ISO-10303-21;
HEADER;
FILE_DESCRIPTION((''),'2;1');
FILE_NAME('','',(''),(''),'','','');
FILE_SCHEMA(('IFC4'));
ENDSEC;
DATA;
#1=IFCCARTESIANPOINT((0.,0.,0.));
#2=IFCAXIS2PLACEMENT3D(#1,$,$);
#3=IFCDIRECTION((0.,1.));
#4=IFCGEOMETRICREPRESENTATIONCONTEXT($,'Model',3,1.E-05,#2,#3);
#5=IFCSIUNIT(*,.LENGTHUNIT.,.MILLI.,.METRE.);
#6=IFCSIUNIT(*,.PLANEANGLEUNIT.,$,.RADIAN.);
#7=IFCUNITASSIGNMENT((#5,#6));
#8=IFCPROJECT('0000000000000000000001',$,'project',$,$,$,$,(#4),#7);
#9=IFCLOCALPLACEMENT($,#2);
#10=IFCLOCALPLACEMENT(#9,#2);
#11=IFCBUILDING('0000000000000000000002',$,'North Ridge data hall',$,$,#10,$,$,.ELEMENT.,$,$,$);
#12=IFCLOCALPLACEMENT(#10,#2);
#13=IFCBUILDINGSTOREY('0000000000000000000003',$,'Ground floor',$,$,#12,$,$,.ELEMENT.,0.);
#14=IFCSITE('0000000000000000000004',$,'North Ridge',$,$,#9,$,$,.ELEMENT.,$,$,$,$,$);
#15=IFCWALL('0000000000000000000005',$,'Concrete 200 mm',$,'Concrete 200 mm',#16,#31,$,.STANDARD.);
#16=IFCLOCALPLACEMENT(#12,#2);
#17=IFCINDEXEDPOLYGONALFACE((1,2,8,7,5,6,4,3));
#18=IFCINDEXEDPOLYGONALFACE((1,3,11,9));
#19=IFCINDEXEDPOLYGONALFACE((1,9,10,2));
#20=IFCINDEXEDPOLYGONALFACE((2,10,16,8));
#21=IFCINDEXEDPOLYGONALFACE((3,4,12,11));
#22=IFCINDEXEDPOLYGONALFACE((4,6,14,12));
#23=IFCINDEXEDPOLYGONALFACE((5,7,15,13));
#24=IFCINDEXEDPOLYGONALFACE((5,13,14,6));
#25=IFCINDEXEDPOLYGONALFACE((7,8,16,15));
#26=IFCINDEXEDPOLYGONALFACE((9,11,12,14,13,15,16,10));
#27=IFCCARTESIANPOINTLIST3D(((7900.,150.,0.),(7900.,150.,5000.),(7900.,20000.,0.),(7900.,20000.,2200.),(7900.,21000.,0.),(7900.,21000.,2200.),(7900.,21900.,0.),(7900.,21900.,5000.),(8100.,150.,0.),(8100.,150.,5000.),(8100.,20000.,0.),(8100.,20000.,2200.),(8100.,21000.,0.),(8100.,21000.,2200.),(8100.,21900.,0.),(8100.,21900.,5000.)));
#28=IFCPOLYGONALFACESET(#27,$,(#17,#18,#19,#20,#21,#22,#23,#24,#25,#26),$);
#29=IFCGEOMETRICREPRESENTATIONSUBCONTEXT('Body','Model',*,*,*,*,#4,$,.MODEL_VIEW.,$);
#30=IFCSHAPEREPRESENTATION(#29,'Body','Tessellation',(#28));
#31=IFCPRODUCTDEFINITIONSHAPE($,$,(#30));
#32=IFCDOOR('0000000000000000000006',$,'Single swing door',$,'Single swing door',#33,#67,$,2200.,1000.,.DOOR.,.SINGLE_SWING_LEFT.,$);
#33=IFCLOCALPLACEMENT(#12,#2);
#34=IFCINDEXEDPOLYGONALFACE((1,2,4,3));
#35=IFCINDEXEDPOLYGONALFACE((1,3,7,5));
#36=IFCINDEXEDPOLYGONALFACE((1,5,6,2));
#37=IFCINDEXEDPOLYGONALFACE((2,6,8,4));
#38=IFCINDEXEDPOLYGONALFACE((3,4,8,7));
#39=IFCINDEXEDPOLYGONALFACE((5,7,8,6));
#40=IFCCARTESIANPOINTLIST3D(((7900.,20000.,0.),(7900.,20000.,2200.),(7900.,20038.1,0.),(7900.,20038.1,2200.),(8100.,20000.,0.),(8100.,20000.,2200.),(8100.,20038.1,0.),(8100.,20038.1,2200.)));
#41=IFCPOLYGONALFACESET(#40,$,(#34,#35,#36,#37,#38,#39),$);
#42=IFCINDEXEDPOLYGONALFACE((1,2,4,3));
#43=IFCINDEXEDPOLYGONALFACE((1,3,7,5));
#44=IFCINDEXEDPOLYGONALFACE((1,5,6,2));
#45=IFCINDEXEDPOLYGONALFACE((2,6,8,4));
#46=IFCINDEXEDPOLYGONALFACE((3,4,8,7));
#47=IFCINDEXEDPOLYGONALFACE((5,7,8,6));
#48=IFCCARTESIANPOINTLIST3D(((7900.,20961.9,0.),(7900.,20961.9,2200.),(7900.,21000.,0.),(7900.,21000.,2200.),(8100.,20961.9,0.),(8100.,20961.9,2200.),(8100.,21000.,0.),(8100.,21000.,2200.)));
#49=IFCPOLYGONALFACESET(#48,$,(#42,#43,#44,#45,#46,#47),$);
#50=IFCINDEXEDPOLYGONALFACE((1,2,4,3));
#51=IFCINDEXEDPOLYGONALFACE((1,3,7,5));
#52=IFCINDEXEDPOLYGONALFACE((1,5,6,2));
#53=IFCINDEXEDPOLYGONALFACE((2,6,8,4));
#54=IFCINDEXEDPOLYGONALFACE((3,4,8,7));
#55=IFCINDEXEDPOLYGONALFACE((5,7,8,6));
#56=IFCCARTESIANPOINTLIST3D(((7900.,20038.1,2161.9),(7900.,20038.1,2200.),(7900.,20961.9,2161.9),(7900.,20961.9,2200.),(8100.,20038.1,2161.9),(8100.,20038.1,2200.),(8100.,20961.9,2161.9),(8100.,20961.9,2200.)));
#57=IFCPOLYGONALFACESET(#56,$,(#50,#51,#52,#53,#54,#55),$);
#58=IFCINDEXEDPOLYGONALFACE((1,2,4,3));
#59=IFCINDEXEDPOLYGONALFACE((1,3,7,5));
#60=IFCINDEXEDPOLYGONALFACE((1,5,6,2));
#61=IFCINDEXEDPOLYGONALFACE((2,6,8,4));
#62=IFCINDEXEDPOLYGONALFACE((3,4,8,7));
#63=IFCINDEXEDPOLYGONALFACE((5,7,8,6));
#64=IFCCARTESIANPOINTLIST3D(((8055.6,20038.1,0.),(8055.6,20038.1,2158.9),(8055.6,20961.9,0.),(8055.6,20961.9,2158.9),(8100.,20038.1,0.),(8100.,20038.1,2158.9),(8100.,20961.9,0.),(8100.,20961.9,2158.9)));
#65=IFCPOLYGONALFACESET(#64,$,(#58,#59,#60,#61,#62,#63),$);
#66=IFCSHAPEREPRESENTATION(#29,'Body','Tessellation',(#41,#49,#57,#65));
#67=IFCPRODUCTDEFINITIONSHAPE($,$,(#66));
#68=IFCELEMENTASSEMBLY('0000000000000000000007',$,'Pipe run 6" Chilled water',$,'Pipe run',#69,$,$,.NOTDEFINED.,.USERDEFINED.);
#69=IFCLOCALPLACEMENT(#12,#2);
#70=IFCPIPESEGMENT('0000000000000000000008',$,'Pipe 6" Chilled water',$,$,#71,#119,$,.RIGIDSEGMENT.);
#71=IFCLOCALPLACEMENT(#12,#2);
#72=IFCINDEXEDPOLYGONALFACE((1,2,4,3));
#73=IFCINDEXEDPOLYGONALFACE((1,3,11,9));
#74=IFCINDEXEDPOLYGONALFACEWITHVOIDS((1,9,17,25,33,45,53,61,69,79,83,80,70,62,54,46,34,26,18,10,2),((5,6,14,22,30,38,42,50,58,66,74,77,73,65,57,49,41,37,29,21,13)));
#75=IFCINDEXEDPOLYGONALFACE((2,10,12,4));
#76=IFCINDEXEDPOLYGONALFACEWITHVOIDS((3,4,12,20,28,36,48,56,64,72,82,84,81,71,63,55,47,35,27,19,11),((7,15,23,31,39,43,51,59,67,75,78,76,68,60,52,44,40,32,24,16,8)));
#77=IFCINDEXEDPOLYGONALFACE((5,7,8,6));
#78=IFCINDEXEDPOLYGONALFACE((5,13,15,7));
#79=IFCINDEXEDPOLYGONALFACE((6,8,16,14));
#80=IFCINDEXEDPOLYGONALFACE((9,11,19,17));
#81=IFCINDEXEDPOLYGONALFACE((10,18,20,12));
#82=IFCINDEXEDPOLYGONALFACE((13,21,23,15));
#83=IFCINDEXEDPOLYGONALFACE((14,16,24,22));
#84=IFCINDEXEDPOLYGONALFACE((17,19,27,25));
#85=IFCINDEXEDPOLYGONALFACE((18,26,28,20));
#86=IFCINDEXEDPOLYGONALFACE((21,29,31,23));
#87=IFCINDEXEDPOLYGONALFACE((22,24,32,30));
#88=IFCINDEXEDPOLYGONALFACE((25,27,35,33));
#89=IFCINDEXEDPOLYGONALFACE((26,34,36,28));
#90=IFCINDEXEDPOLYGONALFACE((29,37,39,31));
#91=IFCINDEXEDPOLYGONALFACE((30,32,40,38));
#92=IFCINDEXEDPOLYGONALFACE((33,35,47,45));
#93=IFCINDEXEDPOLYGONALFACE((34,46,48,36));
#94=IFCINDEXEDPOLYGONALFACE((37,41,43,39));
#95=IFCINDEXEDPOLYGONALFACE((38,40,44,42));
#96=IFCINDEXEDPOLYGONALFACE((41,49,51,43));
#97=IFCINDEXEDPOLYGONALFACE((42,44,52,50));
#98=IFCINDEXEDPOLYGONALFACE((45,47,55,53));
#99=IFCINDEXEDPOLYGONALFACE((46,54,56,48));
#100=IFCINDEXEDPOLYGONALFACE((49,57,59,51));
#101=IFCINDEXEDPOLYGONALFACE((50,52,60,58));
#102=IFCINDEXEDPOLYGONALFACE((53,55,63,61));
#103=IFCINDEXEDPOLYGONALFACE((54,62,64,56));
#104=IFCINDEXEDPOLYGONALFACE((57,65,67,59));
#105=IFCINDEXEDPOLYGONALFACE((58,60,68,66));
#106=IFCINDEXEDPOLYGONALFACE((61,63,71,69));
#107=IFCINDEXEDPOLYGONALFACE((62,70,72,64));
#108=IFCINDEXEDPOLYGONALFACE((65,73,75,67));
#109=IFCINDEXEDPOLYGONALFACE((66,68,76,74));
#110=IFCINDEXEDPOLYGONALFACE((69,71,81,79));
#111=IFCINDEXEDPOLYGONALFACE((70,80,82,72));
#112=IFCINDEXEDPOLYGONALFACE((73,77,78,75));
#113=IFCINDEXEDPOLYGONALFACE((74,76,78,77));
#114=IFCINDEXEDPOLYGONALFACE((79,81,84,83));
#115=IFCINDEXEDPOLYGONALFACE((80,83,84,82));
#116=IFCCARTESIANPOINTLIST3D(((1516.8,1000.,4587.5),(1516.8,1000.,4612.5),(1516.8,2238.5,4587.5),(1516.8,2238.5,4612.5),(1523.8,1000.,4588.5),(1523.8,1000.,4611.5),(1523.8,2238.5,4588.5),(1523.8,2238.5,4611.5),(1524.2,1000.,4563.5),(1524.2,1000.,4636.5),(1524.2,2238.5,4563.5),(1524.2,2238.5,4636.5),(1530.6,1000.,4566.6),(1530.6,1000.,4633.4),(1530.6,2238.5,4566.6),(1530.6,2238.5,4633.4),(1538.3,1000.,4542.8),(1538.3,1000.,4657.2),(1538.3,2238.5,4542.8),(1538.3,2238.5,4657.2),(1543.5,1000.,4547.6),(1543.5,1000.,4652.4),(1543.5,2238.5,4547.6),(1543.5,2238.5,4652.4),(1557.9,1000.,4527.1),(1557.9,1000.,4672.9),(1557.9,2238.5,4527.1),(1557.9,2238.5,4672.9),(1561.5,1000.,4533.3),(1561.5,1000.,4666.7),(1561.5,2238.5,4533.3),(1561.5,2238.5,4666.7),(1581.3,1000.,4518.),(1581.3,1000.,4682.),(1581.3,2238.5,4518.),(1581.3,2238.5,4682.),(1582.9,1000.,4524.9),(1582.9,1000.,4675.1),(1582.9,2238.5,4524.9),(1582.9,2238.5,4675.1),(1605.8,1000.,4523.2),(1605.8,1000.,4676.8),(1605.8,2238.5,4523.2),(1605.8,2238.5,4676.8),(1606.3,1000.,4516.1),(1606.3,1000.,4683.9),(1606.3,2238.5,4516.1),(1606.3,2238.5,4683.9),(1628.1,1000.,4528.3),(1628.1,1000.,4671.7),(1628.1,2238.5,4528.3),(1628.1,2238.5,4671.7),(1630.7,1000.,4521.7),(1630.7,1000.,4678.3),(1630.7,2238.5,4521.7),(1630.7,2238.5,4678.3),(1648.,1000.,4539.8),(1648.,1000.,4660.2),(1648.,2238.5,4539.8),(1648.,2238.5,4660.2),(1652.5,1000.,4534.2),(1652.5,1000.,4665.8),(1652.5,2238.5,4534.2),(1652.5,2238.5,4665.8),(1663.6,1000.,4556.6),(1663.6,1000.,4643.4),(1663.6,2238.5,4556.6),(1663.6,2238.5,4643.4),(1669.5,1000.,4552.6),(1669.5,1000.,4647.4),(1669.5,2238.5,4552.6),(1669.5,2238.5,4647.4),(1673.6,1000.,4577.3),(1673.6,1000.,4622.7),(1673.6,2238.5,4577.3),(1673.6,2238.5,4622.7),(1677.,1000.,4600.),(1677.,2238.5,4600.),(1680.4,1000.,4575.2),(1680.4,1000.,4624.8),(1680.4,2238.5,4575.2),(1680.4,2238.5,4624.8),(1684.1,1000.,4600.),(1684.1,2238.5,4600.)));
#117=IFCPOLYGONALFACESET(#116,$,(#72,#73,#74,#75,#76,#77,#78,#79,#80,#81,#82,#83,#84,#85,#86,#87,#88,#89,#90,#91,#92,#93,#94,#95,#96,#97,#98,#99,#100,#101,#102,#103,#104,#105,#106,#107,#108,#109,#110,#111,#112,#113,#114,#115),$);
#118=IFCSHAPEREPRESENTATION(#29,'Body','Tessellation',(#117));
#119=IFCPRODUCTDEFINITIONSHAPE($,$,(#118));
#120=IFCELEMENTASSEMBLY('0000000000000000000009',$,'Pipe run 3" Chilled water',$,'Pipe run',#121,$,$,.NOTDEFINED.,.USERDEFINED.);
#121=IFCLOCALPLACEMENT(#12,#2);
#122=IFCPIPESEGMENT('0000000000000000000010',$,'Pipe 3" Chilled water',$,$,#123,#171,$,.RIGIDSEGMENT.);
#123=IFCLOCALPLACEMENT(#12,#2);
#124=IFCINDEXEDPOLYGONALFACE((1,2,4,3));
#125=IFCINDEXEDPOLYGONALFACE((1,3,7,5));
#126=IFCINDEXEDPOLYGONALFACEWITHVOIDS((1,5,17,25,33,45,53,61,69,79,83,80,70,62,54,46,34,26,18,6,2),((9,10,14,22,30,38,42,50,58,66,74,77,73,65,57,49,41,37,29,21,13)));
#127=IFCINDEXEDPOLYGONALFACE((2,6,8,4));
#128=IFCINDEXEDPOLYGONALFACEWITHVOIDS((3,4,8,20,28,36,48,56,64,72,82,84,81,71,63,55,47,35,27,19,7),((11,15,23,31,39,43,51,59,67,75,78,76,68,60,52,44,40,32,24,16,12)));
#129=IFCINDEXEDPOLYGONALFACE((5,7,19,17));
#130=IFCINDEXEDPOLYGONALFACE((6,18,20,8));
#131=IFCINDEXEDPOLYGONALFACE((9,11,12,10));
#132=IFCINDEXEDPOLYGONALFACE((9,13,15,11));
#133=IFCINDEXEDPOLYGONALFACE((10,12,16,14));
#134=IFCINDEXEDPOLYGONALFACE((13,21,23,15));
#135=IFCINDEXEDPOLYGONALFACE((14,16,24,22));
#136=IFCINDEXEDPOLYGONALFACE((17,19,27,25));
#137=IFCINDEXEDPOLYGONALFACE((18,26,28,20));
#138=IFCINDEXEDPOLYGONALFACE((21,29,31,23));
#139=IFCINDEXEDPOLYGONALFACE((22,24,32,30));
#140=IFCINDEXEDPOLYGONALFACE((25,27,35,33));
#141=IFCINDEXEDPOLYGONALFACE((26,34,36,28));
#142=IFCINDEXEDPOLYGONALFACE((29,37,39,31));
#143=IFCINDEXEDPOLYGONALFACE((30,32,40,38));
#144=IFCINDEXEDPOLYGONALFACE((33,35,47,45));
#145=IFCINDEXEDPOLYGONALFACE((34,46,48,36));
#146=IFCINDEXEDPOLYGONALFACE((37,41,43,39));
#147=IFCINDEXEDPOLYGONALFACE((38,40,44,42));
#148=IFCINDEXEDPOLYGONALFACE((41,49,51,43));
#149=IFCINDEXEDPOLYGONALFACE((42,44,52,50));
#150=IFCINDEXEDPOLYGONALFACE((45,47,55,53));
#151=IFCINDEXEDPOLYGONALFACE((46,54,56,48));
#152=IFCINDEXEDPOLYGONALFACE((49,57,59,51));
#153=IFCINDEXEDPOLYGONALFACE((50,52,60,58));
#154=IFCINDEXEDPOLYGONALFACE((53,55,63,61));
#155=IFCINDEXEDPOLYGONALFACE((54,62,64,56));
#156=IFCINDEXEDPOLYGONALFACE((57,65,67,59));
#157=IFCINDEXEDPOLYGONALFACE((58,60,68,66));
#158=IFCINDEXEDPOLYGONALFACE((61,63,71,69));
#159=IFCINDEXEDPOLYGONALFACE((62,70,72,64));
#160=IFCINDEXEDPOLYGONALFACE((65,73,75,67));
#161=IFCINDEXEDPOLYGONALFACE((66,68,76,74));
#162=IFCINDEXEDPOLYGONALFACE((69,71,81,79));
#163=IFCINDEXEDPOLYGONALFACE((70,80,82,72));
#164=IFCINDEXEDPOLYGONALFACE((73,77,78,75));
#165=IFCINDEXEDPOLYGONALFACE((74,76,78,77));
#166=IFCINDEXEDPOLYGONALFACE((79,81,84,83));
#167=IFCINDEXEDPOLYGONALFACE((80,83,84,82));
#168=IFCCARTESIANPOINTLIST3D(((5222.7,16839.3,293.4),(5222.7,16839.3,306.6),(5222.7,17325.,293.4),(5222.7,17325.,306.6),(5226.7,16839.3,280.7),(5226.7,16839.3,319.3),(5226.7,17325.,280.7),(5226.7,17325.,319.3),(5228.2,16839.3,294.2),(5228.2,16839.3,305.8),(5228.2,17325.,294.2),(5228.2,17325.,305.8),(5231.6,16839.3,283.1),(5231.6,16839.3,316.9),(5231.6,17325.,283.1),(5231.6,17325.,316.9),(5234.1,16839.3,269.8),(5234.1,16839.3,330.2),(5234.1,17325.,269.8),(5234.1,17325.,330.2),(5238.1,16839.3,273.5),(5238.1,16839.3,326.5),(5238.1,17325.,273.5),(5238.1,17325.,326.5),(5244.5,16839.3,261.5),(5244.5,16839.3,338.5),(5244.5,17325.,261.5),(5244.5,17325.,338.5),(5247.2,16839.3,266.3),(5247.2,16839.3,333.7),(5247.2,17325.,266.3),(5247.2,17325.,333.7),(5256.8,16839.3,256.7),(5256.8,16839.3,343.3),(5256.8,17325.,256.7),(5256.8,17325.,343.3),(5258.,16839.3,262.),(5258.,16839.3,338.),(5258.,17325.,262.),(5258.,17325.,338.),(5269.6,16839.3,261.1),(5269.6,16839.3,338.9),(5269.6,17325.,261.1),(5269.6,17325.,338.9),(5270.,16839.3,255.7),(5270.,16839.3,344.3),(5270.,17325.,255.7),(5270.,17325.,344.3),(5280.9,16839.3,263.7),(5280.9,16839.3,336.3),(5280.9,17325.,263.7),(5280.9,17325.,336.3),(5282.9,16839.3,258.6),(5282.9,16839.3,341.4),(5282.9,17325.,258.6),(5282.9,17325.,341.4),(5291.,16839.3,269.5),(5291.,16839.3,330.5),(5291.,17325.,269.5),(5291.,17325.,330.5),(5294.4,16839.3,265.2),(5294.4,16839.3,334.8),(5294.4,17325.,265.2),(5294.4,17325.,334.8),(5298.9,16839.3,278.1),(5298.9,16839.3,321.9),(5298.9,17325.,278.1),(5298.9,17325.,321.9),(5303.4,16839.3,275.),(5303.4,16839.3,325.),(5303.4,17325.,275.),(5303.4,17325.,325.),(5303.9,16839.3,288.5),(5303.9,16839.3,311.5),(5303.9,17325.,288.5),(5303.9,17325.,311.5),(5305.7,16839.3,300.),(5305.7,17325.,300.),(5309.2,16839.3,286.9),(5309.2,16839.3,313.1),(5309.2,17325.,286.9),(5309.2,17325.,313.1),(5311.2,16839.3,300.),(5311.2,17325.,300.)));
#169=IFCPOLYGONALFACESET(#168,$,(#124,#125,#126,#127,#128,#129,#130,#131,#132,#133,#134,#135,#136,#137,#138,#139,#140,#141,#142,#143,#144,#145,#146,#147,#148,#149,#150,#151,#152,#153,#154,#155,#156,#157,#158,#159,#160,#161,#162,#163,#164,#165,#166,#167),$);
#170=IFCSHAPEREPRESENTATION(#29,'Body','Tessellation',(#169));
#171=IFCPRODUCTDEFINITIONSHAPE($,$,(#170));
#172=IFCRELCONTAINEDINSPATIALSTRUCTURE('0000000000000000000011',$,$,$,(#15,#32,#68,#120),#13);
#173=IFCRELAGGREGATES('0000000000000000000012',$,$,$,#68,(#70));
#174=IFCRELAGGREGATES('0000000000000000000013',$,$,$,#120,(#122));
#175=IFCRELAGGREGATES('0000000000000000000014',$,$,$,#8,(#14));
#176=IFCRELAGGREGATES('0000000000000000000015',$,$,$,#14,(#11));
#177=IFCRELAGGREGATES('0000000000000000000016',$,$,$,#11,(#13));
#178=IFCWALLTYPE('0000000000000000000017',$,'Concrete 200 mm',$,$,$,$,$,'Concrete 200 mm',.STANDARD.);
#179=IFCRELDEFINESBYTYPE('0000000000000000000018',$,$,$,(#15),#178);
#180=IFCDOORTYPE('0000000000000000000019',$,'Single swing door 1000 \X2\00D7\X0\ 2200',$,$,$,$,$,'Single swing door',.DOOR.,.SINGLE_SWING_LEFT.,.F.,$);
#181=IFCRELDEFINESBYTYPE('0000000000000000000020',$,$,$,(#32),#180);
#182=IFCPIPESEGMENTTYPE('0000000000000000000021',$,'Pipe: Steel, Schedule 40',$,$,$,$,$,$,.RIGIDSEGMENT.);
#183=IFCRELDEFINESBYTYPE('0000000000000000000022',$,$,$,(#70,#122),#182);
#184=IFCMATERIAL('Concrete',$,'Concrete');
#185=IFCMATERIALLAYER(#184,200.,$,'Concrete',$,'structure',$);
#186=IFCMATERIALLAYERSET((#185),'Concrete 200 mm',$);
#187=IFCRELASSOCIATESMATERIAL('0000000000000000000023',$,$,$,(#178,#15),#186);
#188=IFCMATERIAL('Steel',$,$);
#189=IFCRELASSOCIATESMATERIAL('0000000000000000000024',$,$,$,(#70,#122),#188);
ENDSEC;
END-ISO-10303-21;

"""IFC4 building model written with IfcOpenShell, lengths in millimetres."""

from ifc_helpers import new_model, si_unit, direction, frame, origin, origin_with_axes, origin_2d, place, context, subcontext, project, spatial, polyline, hollow_circle, outline, extrude, material, layer, layer_set, layer_usage, type_object, element, fill, aggregate, save


model = new_model("IFC4")

# Units and contexts
model_context = context("Model", 3, precision=1e-05, world=origin(), true_north=direction((0.0, 1.0)))
body_context = subcontext(model_context, "Body", "Model", "MODEL_VIEW")
ifc_project = project(units=[si_unit("LENGTHUNIT", "METRE", prefix="MILLI"), si_unit("PLANEANGLEUNIT", "RADIAN")], contexts=[model_context])

# Site, building, storey
site_placement = place(None, origin())
site = spatial("IfcSite", under=ifc_project, at=site_placement, Name="North Ridge", CompositionType="ELEMENT")
building_placement = place(site_placement, origin())
building = spatial("IfcBuilding", under=site, at=building_placement, Name="North Ridge data hall", CompositionType="ELEMENT")
storey_placement = place(building_placement, origin())
storey = spatial("IfcBuildingStorey", under=building, at=storey_placement, Name="Ground floor", CompositionType="ELEMENT", Elevation=0.0)

# Wall, opening, door
ifc_material_1 = material(Name="Concrete", Category="Concrete")
ifc_layer = layer(ifc_material_1, 200.0, Name="Concrete", Category="structure")
ifc_layer_set = layer_set([ifc_layer], Name="Concrete 200 mm")
ifc_layer_usage = layer_usage(ifc_layer_set, "AXIS2", "NEGATIVE", 100.0)
wall_type = type_object("IfcWallType", Name="Concrete 200 mm", ElementType="Concrete 200 mm", PredefinedType="STANDARD", material=ifc_layer_set)
wall_placement = place(storey_placement, frame((8000.0, 0.0, 0.0), z_axis=(0.0, 0.0, 1.0), x_axis=(0.0, 1.0, 0.0)))
wall = element("IfcWall", 1, at=wall_placement, inside=storey, type_object=wall_type, material=ifc_layer_usage, Name="Concrete 200 mm", ObjectType="Concrete 200 mm", PredefinedType="STANDARD", context=body_context, shape_type="SweptSolid", body=[
    extrude(outline(polyline([(150.0, -100.0), (21900.0, -100.0), (21900.0, 100.0), (150.0, 100.0), (150.0, -100.0)])), origin(), (0.0, 0.0, 1.0), 5000.0),
])
opening_placement = place(wall_placement, frame((20000.0, 0.0, 0.0), z_axis=(0.0, 0.0, 1.0), x_axis=(1.0, 0.0, 0.0)))
opening = element("IfcOpeningElement", 2, at=opening_placement, cuts=wall, PredefinedType="OPENING", context=body_context, shape_type="SweptSolid", body=[
    extrude(outline(polyline([(0.0, -110.0), (1000.0, -110.0), (1000.0, 110.0), (0.0, 110.0), (0.0, -110.0)])), origin(), (0.0, 0.0, 1.0), 2200.0),
])
door_type = type_object("IfcDoorType", Name="Single swing door 1000 × 2200", ElementType="Single swing door", OperationType="SINGLE_SWING_LEFT", ParameterTakesPrecedence=False, PredefinedType="DOOR")
door_placement = place(opening_placement, origin_with_axes())
door = element("IfcDoor", 3, at=door_placement, inside=storey, type_object=door_type, Name="Single swing door", ObjectType="Single swing door", OperationType="SINGLE_SWING_LEFT", OverallHeight=2200.0, OverallWidth=1000.0, PredefinedType="DOOR", context=body_context, shape_type="SweptSolid", body=[
    extrude(outline(polyline([(0.0, -100.0), (38.1, -100.0), (38.1, 100.0), (0.0, 100.0), (0.0, -100.0)])), origin(), (0.0, 0.0, 1.0), 2200.0),
    extrude(outline(polyline([(961.9, -100.0), (1000.0, -100.0), (1000.0, 100.0), (961.9, 100.0), (961.9, -100.0)])), origin(), (0.0, 0.0, 1.0), 2200.0),
    extrude(outline(polyline([(38.1, -100.0), (961.9, -100.0), (961.9, 100.0), (38.1, 100.0), (38.1, -100.0)])), frame((0.0, 0.0, 2161.9)), (0.0, 0.0, 1.0), 38.1),
    extrude(outline(polyline([(38.1, -100.0), (961.9, -100.0), (961.9, -55.5), (38.1, -55.5), (38.1, -100.0)])), origin(), (0.0, 0.0, 1.0), 2158.9),
])
fill(opening, door)

# Element assembly, pipe segment
assembly_1_placement = place(storey_placement, origin_with_axes())
assembly_1 = element("IfcElementAssembly", 4, at=assembly_1_placement, inside=storey, Name="Pipe run 6\" Chilled water", ObjectType="Pipe run", AssemblyPlace="NOTDEFINED", PredefinedType="USERDEFINED")
ifc_material_2 = material(Name="Steel")
pipe_segment_type = type_object("IfcPipeSegmentType", Name="Pipe: Steel, Schedule 40", PredefinedType="RIGIDSEGMENT")
pipe_segment_1_placement = place(storey_placement, origin_with_axes())
pipe_segment_1 = element("IfcPipeSegment", 5, at=pipe_segment_1_placement, type_object=pipe_segment_type, material=ifc_material_2, Name="Pipe 6\" Chilled water", PredefinedType="RIGIDSEGMENT", context=body_context, shape_type="SweptSolid", body=[
    extrude(hollow_circle(Radius=84.1, WallThickness=7.1, at=origin_2d()), frame((1600.0, 2238.5, 4600.0), z_axis=(0.0, -1.0, 0.0), x_axis=(1.0, 0.0, 0.0)), (0.0, 0.0, 1.0), 1238.5),
])

# Element assembly, pipe segment
assembly_2_placement = place(storey_placement, origin_with_axes())
assembly_2 = element("IfcElementAssembly", 6, at=assembly_2_placement, inside=storey, Name="Pipe run 3\" Chilled water", ObjectType="Pipe run", AssemblyPlace="NOTDEFINED", PredefinedType="USERDEFINED")
pipe_segment_2_placement = place(storey_placement, origin_with_axes())
pipe_segment_2 = element("IfcPipeSegment", 7, at=pipe_segment_2_placement, type_object=pipe_segment_type, material=ifc_material_2, Name="Pipe 3\" Chilled water", PredefinedType="RIGIDSEGMENT", context=body_context, shape_type="SweptSolid", body=[
    extrude(hollow_circle(Radius=44.5, WallThickness=5.5, at=origin_2d()), frame((5266.7, 17325.0, 300.0), z_axis=(0.0, -1.0, 0.0), x_axis=(1.0, 0.0, 0.0)), (0.0, 0.0, 1.0), 485.7),
])

aggregate(assembly_1, [pipe_segment_1])
aggregate(assembly_2, [pipe_segment_2])

save(model, "model.ifc")
